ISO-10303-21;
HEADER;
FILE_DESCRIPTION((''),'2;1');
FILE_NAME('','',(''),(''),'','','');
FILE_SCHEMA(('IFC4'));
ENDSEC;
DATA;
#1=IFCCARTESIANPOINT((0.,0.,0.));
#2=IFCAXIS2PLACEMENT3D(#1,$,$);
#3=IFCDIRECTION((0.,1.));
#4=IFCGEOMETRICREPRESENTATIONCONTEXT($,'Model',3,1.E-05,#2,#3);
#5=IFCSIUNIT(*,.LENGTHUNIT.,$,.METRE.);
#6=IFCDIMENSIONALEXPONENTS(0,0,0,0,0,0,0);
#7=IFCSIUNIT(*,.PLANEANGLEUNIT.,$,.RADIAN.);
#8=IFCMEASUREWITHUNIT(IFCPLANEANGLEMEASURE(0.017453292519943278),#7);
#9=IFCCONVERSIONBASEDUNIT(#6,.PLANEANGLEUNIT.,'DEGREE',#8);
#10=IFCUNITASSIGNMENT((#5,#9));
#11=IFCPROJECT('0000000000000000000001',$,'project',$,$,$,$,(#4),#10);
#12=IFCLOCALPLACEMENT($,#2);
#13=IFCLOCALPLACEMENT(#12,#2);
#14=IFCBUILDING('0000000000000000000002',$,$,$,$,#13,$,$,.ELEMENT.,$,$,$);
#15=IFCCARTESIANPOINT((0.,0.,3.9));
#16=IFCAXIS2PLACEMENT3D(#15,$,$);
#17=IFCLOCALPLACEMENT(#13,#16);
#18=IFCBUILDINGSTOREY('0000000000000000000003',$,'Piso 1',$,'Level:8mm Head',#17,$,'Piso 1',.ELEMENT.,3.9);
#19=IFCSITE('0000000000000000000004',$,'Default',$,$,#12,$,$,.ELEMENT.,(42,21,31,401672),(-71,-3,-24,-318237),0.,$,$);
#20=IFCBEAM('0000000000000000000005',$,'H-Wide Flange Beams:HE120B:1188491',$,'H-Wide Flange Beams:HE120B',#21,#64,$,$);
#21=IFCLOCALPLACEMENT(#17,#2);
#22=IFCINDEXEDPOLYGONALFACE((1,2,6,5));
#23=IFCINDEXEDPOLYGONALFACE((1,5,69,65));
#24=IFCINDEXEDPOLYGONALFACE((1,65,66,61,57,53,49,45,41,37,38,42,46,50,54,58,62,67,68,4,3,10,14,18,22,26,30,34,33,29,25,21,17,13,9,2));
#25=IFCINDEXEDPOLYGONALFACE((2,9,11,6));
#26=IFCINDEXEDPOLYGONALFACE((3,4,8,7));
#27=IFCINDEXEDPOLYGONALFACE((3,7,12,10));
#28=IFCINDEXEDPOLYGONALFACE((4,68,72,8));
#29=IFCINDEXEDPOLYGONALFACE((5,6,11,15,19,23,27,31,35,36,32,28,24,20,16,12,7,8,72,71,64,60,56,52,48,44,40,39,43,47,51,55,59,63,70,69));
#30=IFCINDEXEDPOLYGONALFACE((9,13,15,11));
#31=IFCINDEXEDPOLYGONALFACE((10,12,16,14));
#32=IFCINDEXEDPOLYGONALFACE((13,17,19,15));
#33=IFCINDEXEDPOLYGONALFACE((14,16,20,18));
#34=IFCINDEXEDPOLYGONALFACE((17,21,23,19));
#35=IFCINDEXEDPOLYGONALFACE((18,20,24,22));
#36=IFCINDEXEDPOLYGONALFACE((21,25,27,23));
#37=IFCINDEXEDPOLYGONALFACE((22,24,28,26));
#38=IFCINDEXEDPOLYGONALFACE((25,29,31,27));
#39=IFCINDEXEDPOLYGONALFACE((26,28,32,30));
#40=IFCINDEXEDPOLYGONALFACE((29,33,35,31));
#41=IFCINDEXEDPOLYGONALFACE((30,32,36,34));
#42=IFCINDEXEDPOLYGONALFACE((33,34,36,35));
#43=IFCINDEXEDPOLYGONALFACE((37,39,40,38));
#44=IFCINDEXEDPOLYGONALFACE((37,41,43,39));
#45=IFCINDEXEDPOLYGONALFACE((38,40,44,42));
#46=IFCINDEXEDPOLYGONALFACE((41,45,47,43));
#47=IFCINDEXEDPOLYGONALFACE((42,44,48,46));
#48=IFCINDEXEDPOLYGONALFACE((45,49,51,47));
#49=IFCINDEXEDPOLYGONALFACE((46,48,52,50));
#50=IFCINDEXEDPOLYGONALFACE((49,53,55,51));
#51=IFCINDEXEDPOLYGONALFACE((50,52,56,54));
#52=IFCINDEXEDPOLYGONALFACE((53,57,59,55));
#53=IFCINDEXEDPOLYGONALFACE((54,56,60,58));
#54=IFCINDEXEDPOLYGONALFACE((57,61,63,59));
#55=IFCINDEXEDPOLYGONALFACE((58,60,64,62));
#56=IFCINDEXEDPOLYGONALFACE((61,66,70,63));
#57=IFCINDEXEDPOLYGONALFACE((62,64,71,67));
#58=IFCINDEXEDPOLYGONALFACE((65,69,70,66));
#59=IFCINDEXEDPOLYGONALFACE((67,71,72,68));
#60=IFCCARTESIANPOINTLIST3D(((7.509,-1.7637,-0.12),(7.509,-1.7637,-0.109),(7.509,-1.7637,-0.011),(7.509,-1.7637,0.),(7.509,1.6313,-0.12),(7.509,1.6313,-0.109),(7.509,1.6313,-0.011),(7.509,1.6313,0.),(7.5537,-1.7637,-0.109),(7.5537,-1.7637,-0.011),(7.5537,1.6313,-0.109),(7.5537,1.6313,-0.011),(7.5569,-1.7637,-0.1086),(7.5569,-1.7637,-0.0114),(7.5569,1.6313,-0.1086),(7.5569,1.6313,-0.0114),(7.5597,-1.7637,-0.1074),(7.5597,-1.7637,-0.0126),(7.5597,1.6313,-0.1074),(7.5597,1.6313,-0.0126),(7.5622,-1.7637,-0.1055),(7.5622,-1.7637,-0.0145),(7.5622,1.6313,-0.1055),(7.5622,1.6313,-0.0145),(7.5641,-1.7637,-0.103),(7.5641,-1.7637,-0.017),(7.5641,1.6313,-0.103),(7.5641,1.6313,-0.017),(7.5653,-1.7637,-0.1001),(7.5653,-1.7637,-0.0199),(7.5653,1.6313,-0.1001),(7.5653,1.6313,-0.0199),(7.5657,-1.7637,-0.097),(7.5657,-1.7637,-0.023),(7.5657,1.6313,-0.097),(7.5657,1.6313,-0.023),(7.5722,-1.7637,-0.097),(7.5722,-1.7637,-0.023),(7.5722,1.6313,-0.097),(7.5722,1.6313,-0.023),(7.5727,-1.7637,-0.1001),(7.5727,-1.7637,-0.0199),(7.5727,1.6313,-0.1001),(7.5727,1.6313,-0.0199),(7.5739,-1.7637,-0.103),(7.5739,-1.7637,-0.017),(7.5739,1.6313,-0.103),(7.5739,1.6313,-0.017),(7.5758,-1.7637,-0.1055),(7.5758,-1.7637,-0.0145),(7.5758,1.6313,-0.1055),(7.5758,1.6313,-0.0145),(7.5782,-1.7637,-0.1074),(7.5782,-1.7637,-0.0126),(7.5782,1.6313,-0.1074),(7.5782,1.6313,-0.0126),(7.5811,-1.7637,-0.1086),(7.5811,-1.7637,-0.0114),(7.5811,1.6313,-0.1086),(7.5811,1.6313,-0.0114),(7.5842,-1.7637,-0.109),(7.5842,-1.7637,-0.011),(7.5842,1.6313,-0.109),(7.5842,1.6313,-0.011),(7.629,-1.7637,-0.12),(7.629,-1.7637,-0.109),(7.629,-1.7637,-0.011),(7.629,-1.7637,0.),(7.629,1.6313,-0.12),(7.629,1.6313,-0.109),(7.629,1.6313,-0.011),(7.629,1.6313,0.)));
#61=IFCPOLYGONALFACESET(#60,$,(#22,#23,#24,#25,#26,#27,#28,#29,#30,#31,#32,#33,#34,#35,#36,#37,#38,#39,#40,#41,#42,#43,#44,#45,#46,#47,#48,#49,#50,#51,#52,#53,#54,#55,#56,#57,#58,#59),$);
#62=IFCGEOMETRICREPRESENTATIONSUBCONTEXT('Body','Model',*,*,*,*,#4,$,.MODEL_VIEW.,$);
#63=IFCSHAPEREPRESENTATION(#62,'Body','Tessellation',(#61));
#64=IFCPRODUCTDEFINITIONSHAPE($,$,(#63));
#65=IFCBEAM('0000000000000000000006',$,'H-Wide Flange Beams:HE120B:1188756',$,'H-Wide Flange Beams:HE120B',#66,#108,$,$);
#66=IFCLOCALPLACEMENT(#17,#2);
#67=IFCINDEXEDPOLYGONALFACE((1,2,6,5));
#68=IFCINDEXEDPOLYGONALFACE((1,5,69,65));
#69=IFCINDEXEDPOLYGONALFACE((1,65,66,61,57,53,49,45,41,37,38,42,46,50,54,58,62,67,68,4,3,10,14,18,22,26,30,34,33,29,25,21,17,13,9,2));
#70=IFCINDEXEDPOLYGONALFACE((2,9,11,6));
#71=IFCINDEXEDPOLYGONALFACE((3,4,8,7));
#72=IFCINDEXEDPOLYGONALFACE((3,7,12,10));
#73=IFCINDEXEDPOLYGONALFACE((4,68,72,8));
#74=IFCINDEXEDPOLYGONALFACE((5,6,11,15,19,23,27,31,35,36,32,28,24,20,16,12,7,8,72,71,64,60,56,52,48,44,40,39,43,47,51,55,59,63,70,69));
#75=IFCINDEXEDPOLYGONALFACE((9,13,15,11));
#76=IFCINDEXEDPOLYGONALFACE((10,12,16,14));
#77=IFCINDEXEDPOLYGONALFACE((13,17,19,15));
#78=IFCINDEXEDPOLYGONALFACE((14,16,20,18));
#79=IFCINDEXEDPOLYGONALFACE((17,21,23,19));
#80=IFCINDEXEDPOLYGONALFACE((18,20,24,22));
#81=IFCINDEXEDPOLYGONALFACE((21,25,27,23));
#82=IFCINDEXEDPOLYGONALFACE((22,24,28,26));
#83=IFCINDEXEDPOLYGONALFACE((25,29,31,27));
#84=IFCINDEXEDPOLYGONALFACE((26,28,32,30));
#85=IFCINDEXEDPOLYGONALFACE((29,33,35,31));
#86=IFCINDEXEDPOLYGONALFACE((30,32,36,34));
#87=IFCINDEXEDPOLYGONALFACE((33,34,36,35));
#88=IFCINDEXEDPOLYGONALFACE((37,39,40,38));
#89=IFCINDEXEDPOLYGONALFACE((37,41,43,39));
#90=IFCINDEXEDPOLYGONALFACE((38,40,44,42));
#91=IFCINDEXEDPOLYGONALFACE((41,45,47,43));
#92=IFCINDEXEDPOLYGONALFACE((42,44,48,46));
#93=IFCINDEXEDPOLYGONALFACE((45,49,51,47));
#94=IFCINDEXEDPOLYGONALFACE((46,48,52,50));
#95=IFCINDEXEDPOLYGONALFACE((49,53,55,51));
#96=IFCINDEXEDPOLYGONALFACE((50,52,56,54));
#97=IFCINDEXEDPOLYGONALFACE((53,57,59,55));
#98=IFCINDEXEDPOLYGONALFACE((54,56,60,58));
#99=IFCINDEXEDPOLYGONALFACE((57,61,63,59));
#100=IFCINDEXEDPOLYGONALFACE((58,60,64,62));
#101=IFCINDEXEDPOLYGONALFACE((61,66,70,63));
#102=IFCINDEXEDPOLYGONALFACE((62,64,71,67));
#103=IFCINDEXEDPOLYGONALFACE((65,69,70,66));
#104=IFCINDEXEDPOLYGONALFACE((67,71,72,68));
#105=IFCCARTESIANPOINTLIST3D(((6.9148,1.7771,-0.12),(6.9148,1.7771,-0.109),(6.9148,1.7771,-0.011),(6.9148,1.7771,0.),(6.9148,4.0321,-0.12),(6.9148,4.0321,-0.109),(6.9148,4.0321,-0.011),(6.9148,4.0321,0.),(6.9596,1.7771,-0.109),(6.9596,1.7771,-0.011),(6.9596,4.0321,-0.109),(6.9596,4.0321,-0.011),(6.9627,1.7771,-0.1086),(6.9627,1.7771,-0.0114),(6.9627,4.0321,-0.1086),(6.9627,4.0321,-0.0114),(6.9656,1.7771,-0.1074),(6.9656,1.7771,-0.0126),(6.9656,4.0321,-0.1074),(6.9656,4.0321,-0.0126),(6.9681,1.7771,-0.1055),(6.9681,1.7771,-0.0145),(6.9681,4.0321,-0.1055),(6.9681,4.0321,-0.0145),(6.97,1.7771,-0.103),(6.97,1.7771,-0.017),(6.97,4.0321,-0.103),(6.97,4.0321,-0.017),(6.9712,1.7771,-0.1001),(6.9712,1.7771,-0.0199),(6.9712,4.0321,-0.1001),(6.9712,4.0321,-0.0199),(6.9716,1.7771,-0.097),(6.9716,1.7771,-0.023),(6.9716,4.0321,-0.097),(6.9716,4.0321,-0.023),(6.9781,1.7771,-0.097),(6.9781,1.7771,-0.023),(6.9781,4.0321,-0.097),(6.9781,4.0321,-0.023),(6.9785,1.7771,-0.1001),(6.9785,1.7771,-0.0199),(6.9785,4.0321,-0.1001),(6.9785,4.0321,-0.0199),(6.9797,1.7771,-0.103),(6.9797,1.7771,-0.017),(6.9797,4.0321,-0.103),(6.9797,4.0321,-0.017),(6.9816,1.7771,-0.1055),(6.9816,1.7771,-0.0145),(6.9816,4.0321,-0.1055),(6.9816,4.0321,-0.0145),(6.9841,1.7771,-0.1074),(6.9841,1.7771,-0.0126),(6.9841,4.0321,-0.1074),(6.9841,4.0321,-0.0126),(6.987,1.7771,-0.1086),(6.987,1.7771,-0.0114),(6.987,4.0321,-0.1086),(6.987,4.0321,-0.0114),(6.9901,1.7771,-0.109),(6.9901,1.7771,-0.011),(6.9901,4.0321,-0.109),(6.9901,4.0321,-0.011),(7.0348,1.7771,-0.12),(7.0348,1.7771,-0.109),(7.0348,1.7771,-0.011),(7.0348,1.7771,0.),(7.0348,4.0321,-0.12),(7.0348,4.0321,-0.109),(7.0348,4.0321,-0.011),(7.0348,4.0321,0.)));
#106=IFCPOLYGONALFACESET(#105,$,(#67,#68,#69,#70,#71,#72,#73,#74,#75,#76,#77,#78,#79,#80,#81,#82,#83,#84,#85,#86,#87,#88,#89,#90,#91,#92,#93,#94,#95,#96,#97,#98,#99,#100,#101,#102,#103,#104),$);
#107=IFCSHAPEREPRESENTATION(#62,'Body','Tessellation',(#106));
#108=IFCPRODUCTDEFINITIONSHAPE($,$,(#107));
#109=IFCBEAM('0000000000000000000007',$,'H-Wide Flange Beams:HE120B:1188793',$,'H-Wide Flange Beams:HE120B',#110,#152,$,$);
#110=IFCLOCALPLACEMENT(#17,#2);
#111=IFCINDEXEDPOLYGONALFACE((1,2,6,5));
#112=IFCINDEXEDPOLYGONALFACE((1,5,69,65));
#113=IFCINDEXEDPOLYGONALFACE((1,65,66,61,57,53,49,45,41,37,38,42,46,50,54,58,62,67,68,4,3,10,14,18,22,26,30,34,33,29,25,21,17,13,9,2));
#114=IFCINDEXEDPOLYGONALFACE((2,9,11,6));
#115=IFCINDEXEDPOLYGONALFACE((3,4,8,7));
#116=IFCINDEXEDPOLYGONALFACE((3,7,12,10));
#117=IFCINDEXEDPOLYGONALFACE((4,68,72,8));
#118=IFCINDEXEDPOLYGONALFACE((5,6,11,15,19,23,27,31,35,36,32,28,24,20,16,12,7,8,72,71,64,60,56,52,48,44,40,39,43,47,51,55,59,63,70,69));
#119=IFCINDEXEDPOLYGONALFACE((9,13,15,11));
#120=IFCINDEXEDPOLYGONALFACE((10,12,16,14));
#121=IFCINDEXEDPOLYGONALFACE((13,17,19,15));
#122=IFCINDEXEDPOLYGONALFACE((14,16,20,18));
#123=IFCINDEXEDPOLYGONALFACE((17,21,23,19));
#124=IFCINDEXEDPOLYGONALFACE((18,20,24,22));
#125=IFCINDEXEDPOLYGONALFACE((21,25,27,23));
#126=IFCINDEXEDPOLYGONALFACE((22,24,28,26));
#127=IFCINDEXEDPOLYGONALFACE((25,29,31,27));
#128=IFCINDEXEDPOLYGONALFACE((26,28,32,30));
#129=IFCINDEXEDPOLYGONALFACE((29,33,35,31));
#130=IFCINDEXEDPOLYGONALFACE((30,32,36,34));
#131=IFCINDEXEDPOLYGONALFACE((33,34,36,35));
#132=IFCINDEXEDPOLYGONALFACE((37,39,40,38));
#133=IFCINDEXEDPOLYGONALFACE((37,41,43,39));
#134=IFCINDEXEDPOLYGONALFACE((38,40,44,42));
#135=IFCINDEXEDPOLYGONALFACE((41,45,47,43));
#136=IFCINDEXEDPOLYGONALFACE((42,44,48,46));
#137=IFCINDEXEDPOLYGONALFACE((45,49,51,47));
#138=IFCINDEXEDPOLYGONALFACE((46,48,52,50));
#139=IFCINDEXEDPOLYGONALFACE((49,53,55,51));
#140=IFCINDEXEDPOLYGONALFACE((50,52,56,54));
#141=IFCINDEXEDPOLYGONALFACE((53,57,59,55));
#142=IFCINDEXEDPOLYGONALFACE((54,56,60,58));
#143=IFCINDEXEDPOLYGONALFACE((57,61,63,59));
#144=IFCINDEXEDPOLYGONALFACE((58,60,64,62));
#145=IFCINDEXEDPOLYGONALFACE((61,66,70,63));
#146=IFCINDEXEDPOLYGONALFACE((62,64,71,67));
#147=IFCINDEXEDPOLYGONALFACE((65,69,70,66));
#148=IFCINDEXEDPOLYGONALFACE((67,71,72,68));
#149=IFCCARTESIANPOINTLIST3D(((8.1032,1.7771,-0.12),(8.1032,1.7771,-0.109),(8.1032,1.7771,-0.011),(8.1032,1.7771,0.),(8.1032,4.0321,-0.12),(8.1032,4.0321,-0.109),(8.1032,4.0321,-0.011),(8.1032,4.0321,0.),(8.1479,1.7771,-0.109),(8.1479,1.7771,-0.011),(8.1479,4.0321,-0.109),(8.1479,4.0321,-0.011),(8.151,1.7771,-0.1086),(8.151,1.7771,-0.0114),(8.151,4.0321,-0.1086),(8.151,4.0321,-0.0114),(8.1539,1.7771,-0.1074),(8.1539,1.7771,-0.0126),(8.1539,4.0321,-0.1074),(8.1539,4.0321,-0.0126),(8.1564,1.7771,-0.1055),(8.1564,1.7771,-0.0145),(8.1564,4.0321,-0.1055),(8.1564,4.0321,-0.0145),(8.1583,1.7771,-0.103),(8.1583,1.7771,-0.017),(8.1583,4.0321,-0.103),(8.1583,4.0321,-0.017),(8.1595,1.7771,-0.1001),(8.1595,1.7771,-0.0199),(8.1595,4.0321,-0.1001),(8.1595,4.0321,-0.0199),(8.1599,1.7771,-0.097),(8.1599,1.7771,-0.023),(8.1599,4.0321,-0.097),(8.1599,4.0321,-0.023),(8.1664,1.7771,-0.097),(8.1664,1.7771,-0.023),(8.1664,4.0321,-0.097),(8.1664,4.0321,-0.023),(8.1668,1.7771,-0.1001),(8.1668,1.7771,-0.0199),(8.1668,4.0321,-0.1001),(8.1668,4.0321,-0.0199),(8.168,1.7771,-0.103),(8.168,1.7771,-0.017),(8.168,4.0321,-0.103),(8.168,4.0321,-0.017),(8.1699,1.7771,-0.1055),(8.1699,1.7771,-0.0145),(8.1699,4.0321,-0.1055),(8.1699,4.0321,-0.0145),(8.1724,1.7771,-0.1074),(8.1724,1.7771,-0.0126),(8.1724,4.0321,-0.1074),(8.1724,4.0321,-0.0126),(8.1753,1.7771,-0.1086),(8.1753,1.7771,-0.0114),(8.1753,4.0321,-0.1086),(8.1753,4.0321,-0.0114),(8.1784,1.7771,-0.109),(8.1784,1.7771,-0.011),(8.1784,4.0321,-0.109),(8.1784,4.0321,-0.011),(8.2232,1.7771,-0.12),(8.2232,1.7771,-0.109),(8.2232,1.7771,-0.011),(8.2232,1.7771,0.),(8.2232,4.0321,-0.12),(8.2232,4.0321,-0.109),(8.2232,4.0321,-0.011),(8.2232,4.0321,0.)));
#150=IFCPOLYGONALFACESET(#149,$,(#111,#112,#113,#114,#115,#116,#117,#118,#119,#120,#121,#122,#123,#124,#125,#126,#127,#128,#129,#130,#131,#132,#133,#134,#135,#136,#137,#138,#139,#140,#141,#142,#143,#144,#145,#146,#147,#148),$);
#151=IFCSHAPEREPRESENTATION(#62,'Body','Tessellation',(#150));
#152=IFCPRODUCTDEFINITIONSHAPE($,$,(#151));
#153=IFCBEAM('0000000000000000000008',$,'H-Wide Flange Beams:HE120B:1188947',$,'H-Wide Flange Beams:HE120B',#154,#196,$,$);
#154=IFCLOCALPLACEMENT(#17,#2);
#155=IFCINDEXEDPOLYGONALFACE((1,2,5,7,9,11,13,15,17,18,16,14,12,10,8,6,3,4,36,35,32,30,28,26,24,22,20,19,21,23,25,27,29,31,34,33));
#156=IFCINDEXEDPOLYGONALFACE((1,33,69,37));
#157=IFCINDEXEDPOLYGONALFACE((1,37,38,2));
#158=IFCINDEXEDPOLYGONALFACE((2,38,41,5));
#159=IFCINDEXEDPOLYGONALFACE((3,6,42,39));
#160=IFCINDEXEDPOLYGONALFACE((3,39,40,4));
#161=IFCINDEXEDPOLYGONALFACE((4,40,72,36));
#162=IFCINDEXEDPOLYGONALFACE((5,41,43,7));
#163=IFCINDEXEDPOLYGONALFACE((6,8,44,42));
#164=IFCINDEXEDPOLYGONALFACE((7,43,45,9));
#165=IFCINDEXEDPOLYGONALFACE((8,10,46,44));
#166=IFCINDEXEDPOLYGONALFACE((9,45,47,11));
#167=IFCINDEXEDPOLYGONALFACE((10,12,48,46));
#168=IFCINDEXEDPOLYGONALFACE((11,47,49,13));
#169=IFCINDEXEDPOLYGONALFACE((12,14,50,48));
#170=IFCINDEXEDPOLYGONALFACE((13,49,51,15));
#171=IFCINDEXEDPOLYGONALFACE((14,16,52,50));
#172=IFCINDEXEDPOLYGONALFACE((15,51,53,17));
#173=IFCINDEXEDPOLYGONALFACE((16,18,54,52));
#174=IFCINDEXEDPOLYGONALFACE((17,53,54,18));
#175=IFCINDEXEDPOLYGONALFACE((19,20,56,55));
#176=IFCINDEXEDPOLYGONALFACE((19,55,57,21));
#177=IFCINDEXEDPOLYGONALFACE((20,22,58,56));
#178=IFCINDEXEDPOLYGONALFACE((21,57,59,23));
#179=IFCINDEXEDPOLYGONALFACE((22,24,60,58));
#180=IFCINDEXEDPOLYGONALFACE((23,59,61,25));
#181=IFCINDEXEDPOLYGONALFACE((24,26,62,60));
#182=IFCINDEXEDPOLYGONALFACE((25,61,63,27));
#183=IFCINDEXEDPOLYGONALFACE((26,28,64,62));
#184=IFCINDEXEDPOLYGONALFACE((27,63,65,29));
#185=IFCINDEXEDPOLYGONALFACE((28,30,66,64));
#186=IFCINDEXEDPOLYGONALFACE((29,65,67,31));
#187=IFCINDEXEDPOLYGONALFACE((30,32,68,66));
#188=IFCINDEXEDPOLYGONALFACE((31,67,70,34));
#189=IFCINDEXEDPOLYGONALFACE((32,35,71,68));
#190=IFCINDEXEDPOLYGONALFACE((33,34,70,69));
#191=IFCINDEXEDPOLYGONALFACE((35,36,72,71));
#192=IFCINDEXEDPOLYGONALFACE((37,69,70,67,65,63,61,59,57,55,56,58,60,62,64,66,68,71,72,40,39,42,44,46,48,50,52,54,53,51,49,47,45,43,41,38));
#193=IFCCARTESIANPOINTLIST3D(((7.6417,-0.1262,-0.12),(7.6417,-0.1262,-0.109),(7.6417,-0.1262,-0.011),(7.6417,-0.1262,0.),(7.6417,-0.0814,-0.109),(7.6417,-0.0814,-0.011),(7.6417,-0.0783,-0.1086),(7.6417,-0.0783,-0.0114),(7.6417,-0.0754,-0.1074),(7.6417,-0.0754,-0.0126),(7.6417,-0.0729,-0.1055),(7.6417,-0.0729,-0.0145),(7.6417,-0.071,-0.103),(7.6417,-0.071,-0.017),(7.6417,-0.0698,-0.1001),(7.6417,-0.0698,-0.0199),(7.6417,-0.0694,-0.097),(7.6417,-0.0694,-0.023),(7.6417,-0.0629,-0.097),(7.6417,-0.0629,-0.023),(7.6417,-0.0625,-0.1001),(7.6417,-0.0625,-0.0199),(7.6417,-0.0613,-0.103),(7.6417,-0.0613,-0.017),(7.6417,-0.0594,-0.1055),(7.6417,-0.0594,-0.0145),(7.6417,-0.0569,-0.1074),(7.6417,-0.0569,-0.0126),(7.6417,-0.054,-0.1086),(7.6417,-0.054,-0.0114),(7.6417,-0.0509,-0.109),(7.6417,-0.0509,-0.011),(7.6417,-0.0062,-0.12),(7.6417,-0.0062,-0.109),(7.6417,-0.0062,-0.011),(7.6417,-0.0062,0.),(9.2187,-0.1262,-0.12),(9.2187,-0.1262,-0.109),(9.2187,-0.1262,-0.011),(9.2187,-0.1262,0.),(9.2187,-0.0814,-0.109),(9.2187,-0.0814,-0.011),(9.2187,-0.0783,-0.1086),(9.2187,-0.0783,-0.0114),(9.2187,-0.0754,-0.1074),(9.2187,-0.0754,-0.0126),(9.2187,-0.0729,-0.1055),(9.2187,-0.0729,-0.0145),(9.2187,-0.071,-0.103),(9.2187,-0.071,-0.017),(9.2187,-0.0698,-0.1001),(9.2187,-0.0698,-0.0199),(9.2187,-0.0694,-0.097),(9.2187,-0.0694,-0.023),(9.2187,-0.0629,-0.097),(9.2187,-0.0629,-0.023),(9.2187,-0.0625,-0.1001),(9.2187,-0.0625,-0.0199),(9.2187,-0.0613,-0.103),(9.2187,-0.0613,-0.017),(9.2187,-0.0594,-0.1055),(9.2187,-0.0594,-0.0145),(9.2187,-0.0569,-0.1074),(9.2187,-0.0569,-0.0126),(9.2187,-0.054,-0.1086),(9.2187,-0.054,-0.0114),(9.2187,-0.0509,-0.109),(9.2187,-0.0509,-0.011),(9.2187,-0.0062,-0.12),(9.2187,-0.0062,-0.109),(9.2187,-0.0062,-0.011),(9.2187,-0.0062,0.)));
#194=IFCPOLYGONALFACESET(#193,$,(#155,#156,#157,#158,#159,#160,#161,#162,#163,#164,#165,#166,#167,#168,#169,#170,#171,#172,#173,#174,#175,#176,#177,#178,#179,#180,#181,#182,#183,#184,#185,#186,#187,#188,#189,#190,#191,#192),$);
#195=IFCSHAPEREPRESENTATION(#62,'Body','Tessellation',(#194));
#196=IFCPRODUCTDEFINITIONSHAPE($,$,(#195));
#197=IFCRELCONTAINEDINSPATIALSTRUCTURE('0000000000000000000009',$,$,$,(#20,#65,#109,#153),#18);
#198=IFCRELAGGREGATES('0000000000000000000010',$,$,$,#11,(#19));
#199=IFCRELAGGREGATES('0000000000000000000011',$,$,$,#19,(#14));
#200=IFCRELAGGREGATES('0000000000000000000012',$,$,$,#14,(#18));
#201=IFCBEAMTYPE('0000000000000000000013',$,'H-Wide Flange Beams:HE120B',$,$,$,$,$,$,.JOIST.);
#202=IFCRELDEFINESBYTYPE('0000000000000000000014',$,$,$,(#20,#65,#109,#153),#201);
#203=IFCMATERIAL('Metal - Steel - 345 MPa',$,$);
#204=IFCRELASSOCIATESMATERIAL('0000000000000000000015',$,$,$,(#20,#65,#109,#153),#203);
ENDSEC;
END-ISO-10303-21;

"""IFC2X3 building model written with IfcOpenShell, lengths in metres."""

from ifc_helpers import new_model, entity, si_unit, converted_unit, direction, frame, frame_2d, origin, place, context, subcontext, project, spatial, i_section, extrude, material, type_object, element, save


model = new_model("IFC2X3")

# Units and contexts
model_context = context("Model", 3, precision=1e-05, world=origin(), true_north=direction((0.0, 1.0)))
body_context = subcontext(model_context, "Body", "Model", "MODEL_VIEW")
ifc_project = project(units=[si_unit("LENGTHUNIT", "METRE"), converted_unit("PLANEANGLEUNIT", "DEGREE", entity("IfcPlaneAngleMeasure", 0.017453292519943278), si_unit("PLANEANGLEUNIT", "RADIAN"), dimensions=[0, 0, 0, 0, 0, 0, 0])], contexts=[model_context])

# Site, building, storey
site_placement = place(None, origin())
site = spatial("IfcSite", under=ifc_project, at=site_placement, Name="Default", CompositionType="ELEMENT", RefLatitude=(42, 21, 31, 401672), RefLongitude=(-71, -3, -24, -318237), RefElevation=0.0)
building_placement = place(site_placement, origin())
building = spatial("IfcBuilding", under=site, at=building_placement, CompositionType="ELEMENT")
storey_placement = place(building_placement, frame((0.0, 0.0, 3.9)))
storey = spatial("IfcBuildingStorey", under=building, at=storey_placement, Name="Piso 1", ObjectType="Level:8mm Head", LongName="Piso 1", CompositionType="ELEMENT", Elevation=3.9)

# Beams
ifc_material = material(Name="Metal - Steel - 345 MPa")
beam_type_1 = type_object("IfcBeamType", Name="H-Wide Flange Beams:HE120B", PredefinedType="JOIST")
beam_1_placement = place(storey_placement, frame((7.569, 1.7041, 0.0), z_axis=(0.0, 0.0, 1.0), x_axis=(0.0, -1.0, 0.0)))
element("IfcBeam", 1, at=beam_1_placement, inside=storey, type_object=beam_type_1, material=ifc_material, Name="H-Wide Flange Beams:HE120B:1188491", ObjectType="H-Wide Flange Beams:HE120B", context=body_context, shape_type="SweptSolid", body=[
    extrude(i_section(OverallWidth=0.12, OverallDepth=0.12, WebThickness=0.0065, FlangeThickness=0.011, FilletRadius=0.012, at=frame_2d((0.0, 0.0), x_axis=(0.0, 1.0))), frame((0.0728, 0.0, -0.06), z_axis=(1.0, 0.0, 0.0), x_axis=(0.0, 0.0, -1.0)), (0.0, 0.0, 1.0), 3.395),
])
beam_2_placement = place(storey_placement, frame((6.9748, 4.1052, 0.0), z_axis=(0.0, 0.0, 1.0), x_axis=(0.0, -1.0, 0.0)))
element("IfcBeam", 2, at=beam_2_placement, inside=storey, type_object=beam_type_1, material=ifc_material, Name="H-Wide Flange Beams:HE120B:1188756", ObjectType="H-Wide Flange Beams:HE120B", context=body_context, shape_type="SweptSolid", body=[
    extrude(i_section(OverallWidth=0.12, OverallDepth=0.12, WebThickness=0.0065, FlangeThickness=0.011, FilletRadius=0.012, at=frame_2d((0.0, 0.0), x_axis=(0.0, 1.0))), frame((0.073, 0.0, -0.06), z_axis=(1.0, 0.0, 0.0), x_axis=(0.0, 0.0, -1.0)), (0.0, 0.0, 1.0), 2.255),
])
beam_3_placement = place(storey_placement, frame((8.1632, 4.1052, 0.0), z_axis=(0.0, 0.0, 1.0), x_axis=(0.0, -1.0, 0.0)))
element("IfcBeam", 3, at=beam_3_placement, inside=storey, type_object=beam_type_1, material=ifc_material, Name="H-Wide Flange Beams:HE120B:1188793", ObjectType="H-Wide Flange Beams:HE120B", context=body_context, shape_type="SweptSolid", body=[
    extrude(i_section(OverallWidth=0.12, OverallDepth=0.12, WebThickness=0.0065, FlangeThickness=0.011, FilletRadius=0.012, at=frame_2d((0.0, 0.0), x_axis=(0.0, 1.0))), frame((0.073, 0.0, -0.06), z_axis=(1.0, 0.0, 0.0), x_axis=(0.0, 0.0, -1.0)), (0.0, 0.0, 1.0), 2.255),
])
beam_4_placement = place(storey_placement, frame((7.569, -0.0662, 0.0)))
element("IfcBeam", 4, at=beam_4_placement, inside=storey, type_object=beam_type_1, material=ifc_material, Name="H-Wide Flange Beams:HE120B:1188947", ObjectType="H-Wide Flange Beams:HE120B", context=body_context, shape_type="SweptSolid", body=[
    extrude(i_section(OverallWidth=0.12, OverallDepth=0.12, WebThickness=0.0065, FlangeThickness=0.011, FilletRadius=0.012, at=frame_2d((0.0, 0.0), x_axis=(0.0, 1.0))), frame((0.0727, 0.0, -0.06), z_axis=(1.0, 0.0, 0.0), x_axis=(0.0, 0.0, -1.0)), (0.0, 0.0, 1.0), 1.577),
])

save(model, "model.ifc")
